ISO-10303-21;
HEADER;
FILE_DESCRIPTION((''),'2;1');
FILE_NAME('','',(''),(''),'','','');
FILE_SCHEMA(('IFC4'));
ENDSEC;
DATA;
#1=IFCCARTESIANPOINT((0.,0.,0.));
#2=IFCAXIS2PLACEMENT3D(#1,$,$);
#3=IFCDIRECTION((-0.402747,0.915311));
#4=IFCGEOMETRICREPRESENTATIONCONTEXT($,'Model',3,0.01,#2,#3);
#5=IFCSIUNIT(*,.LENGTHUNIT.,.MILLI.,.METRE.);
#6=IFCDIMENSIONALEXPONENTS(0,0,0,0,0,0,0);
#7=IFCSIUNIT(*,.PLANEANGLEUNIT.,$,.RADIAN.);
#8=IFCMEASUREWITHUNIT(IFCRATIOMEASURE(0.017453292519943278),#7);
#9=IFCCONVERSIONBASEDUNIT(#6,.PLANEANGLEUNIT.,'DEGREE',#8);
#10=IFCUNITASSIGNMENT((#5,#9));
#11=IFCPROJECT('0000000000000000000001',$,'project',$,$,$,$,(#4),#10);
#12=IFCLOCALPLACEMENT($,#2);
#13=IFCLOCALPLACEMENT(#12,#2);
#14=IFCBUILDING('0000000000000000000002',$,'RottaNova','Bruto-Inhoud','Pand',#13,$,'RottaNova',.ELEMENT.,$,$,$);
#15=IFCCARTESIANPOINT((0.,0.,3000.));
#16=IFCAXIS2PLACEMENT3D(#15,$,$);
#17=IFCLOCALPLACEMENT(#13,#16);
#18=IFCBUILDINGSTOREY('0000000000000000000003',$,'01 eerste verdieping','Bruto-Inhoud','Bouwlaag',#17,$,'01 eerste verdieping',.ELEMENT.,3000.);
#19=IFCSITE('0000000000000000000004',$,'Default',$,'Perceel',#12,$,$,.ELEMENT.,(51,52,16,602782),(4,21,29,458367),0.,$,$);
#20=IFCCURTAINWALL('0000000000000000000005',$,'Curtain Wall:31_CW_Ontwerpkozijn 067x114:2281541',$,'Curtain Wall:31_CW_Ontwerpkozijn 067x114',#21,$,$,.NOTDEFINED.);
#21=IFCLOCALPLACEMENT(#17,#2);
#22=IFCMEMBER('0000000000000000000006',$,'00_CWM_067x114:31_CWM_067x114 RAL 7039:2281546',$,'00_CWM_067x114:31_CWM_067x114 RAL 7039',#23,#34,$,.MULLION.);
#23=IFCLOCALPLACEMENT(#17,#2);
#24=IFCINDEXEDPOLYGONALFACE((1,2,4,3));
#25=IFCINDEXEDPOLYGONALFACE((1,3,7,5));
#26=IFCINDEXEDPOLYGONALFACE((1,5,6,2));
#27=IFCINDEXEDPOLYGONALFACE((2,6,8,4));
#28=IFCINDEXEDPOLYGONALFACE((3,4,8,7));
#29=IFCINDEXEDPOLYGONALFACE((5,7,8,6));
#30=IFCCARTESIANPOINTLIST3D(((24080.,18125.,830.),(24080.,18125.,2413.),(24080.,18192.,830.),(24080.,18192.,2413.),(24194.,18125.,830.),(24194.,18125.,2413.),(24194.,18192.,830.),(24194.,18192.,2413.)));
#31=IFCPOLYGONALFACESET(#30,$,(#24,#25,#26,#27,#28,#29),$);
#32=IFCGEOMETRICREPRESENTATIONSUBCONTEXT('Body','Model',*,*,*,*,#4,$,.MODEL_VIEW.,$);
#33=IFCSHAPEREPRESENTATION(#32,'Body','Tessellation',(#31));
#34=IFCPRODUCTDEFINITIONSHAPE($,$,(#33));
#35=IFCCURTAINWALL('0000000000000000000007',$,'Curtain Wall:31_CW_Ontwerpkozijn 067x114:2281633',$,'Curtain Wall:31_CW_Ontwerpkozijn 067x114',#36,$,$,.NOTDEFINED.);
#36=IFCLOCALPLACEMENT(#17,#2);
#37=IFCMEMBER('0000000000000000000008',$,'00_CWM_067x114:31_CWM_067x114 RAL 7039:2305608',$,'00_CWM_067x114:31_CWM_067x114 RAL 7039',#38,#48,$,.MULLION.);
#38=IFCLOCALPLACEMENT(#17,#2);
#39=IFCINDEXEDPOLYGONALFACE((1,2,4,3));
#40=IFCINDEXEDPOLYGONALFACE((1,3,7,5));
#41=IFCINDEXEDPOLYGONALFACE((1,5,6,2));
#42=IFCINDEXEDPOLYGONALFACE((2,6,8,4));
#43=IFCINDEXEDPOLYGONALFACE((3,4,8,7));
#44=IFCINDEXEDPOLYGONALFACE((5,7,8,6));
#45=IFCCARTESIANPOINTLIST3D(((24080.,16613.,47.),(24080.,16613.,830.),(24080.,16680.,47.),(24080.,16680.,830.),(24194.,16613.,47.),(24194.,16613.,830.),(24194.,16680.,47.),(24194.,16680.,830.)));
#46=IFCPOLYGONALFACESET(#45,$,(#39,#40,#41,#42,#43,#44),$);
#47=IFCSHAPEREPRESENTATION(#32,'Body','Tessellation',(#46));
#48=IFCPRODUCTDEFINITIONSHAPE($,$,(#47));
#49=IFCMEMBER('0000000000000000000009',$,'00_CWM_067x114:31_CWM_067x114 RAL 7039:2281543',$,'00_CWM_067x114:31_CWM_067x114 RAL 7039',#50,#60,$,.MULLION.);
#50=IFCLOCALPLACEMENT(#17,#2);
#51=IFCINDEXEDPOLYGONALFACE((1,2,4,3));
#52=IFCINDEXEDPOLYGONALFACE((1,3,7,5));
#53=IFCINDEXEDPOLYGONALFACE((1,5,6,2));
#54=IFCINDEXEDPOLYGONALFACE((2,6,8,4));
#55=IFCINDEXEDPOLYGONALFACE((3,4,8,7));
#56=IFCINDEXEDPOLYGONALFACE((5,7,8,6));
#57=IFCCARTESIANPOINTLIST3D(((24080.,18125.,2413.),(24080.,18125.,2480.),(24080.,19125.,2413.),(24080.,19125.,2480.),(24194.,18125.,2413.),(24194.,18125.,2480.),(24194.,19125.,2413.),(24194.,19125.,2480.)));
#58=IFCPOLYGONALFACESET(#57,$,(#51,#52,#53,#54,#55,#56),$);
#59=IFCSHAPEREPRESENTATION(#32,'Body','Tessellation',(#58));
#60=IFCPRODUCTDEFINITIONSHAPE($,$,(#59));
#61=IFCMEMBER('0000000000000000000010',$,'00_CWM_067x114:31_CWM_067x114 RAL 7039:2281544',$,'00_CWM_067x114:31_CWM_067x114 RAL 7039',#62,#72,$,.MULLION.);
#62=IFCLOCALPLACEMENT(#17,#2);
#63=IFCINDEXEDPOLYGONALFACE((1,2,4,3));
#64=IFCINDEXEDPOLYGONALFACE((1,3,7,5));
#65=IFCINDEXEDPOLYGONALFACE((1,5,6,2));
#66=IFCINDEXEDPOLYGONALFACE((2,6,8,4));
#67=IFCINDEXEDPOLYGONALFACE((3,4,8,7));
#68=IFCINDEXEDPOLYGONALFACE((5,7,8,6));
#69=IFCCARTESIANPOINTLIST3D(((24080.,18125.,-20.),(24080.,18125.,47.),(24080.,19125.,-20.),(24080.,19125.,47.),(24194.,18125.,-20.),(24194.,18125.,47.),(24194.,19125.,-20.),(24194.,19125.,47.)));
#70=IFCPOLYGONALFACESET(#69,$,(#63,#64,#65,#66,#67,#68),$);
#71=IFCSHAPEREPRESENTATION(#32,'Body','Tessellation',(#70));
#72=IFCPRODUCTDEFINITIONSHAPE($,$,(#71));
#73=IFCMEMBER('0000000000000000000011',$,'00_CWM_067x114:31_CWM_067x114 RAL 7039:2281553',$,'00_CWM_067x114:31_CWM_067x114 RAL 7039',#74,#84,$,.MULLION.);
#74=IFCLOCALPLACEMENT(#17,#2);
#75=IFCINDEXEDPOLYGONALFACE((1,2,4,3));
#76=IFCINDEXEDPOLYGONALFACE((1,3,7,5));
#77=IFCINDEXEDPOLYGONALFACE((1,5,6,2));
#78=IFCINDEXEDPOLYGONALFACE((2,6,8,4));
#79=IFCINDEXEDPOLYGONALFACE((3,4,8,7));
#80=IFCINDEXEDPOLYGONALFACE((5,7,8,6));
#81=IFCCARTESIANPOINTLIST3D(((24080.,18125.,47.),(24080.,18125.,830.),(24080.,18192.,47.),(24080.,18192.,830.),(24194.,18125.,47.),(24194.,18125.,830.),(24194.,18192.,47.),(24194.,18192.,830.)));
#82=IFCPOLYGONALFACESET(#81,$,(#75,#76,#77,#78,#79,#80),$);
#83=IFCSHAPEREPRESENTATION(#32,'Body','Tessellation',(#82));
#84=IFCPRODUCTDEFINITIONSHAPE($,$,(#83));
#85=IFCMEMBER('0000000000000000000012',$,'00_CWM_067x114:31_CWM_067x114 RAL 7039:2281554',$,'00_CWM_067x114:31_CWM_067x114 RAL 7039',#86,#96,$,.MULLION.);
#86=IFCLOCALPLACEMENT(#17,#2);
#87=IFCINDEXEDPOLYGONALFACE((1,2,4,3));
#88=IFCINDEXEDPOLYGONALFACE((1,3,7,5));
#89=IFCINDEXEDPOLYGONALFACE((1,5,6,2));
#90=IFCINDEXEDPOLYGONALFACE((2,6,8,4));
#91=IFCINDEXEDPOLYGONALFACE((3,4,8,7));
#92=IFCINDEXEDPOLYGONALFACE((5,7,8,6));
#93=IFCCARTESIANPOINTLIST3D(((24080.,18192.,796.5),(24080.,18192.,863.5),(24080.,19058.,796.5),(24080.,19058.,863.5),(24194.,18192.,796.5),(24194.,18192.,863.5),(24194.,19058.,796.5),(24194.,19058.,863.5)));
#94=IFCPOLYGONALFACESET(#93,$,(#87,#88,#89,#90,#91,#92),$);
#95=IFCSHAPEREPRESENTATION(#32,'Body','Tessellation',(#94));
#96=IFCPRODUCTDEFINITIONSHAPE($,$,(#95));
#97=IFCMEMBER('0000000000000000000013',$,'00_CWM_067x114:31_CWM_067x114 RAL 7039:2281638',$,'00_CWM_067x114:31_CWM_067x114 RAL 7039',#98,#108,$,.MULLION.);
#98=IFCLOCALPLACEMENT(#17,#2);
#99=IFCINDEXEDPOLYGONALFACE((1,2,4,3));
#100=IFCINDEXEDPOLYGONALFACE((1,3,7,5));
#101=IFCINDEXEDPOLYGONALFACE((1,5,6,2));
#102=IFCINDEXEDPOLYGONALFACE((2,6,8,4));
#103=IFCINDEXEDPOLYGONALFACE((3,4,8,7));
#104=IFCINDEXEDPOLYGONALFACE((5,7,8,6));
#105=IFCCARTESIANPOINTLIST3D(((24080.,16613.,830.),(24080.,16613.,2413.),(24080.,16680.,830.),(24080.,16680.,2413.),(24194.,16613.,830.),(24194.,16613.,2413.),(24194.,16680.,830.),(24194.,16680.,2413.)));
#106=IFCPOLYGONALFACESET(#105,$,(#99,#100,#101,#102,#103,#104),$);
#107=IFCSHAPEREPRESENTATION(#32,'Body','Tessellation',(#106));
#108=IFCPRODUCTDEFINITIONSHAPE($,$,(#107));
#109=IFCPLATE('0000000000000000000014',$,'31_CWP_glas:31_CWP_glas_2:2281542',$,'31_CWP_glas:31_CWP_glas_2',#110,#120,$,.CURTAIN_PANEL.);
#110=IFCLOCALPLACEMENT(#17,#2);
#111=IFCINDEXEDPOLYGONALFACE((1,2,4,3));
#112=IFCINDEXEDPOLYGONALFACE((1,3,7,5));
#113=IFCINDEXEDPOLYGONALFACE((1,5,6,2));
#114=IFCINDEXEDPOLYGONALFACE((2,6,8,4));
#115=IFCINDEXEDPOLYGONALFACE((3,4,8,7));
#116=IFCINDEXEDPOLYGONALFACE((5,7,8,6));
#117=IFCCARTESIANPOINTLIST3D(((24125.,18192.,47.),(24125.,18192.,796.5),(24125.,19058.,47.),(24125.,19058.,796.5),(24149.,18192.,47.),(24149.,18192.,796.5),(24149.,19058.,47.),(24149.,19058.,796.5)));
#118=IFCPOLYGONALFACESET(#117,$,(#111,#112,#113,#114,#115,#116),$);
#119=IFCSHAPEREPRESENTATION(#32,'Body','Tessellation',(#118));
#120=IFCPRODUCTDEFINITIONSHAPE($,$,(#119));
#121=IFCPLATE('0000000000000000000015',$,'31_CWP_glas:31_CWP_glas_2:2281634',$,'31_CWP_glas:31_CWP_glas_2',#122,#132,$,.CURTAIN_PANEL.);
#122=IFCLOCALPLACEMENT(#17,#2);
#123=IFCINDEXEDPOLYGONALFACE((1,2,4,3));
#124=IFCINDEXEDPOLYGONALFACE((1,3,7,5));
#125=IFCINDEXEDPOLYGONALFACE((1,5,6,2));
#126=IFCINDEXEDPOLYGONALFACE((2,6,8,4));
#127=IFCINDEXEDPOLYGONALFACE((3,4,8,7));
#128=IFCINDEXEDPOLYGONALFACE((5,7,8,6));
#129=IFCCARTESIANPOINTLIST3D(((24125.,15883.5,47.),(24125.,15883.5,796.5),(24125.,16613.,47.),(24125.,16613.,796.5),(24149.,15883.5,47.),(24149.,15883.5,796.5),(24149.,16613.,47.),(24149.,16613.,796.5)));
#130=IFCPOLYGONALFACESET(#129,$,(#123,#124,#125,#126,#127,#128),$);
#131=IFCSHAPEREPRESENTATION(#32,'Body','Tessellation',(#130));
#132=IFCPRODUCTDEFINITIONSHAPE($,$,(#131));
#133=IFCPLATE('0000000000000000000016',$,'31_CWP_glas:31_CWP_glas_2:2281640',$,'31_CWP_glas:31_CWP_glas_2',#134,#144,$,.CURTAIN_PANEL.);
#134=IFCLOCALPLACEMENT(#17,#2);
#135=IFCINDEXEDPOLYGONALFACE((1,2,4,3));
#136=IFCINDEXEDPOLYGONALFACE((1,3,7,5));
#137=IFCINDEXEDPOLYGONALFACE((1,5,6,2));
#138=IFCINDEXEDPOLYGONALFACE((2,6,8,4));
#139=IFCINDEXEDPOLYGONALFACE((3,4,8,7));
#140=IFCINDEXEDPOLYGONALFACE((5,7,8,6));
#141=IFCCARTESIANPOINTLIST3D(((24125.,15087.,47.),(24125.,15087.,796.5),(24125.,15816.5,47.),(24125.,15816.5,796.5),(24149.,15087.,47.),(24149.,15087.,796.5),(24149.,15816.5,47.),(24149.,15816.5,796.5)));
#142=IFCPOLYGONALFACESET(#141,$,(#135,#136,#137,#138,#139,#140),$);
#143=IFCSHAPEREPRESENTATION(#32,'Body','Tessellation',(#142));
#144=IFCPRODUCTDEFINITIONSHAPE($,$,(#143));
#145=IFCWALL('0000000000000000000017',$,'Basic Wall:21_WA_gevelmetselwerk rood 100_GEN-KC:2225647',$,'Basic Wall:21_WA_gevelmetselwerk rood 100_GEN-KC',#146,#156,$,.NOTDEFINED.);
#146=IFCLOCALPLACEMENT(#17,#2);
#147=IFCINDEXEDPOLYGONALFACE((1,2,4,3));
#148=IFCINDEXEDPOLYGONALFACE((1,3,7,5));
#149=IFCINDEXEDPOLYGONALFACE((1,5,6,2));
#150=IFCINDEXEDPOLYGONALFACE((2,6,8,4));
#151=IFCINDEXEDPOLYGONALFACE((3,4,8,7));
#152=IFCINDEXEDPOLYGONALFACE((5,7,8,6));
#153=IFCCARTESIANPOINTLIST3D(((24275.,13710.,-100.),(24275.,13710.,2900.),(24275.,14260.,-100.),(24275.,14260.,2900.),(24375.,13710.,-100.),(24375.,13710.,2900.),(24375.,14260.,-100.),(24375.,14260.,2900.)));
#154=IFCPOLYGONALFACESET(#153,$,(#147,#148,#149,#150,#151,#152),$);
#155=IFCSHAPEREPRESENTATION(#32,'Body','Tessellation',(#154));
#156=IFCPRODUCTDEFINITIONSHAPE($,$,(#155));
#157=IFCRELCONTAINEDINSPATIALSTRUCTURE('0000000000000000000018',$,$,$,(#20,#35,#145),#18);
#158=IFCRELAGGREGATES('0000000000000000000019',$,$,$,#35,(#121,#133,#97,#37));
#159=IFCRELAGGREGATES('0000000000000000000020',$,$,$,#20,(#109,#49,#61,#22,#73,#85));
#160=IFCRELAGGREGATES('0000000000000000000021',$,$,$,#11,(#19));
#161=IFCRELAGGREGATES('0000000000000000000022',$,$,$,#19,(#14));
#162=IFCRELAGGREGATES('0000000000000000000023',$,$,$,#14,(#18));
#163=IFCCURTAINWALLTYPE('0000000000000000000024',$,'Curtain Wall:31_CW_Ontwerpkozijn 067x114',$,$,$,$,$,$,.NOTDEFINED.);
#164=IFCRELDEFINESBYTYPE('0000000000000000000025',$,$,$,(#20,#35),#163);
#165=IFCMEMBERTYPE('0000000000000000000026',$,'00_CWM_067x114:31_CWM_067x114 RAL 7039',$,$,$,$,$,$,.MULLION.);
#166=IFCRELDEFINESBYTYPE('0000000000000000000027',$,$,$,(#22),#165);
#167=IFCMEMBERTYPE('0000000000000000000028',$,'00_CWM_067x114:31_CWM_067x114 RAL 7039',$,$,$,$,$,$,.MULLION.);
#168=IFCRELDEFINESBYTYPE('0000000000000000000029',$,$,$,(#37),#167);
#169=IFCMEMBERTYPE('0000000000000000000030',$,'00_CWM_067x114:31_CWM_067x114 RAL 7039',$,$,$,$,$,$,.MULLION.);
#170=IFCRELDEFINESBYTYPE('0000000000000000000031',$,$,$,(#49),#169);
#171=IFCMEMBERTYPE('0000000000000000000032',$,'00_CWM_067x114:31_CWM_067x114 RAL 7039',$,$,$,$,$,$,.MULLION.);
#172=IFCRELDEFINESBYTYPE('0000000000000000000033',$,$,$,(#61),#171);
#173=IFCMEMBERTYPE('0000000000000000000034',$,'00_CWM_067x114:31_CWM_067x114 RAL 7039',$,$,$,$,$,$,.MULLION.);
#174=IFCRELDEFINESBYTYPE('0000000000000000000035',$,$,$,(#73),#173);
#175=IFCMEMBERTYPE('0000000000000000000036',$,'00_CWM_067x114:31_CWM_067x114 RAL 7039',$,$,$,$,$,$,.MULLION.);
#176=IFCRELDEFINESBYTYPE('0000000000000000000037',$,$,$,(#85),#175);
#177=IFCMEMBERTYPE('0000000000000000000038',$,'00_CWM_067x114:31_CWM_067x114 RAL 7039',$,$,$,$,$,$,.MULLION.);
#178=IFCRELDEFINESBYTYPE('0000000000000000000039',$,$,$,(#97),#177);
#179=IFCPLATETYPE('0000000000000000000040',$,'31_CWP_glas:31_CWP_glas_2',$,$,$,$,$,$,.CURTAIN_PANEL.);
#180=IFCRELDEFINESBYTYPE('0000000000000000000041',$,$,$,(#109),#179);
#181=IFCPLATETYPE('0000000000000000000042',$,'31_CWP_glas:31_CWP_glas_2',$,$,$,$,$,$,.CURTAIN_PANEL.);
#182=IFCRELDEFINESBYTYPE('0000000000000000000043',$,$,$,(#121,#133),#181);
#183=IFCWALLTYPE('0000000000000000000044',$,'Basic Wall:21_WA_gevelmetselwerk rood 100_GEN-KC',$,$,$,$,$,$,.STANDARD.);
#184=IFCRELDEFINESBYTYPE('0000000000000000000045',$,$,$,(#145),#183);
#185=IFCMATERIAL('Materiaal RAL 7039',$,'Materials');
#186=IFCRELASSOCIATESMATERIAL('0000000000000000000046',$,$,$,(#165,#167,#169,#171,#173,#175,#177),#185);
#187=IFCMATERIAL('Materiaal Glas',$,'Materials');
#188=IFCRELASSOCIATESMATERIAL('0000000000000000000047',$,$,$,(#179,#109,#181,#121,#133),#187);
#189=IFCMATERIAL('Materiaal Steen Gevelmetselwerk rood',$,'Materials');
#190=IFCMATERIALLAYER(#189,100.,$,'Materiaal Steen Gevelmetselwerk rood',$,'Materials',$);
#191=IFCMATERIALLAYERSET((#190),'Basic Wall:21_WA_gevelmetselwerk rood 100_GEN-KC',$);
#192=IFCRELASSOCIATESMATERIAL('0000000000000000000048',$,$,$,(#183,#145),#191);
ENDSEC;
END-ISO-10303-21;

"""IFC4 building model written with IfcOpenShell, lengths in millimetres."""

from ifc_helpers import new_model, entity, si_unit, converted_unit, direction, frame, frame_2d, origin, origin_2d_with_axis, place, context, subcontext, project, spatial, rectangle, extrude, source, transform, mapped, material, layer, layer_set, material_profile, profile_set, type_object, type_shapes, element, aggregate, save


model = new_model("IFC4")

# Units and contexts
model_context = context("Model", 3, precision=0.01, world=origin(), true_north=direction((-0.402747, 0.915311)))
body_context = subcontext(model_context, "Body", "Model", "MODEL_VIEW")
ifc_project = project(units=[si_unit("LENGTHUNIT", "METRE", prefix="MILLI"), converted_unit("PLANEANGLEUNIT", "DEGREE", entity("IfcRatioMeasure", 0.017453292519943278), si_unit("PLANEANGLEUNIT", "RADIAN"), dimensions=[0, 0, 0, 0, 0, 0, 0])], contexts=[model_context])

# Site, building, storey
site_placement = place(None, origin())
site = spatial("IfcSite", under=ifc_project, at=site_placement, Name="Default", ObjectType="Perceel", CompositionType="ELEMENT", RefLatitude=(51, 52, 16, 602782), RefLongitude=(4, 21, 29, 458367), RefElevation=0.0)
building_placement = place(site_placement, origin())
building = spatial("IfcBuilding", under=site, at=building_placement, Name="RottaNova", Description="Bruto-Inhoud", ObjectType="Pand", LongName="RottaNova", CompositionType="ELEMENT")
storey_placement = place(building_placement, frame((0.0, 0.0, 3000.0)))
storey = spatial("IfcBuildingStorey", under=building, at=storey_placement, Name="01 eerste verdieping", Description="Bruto-Inhoud", ObjectType="Bouwlaag", LongName="01 eerste verdieping", CompositionType="ELEMENT", Elevation=3000.0)

# Curtain walls, members
curtain_wall_type = type_object("IfcCurtainWallType", Name="Curtain Wall:31_CW_Ontwerpkozijn 067x114", PredefinedType="NOTDEFINED")
curtain_wall_1_placement = place(storey_placement, frame((0.0, 0.0, -3000.0)))
curtain_wall_1 = element("IfcCurtainWall", 1, at=curtain_wall_1_placement, inside=storey, type_object=curtain_wall_type, Name="Curtain Wall:31_CW_Ontwerpkozijn 067x114:2281541", ObjectType="Curtain Wall:31_CW_Ontwerpkozijn 067x114", PredefinedType="NOTDEFINED")
ifc_material_1 = material(Name="Materiaal RAL 7039", Category="Materials")
ifc_material_profile = material_profile(ifc_material_1, rectangle(XDim=114.0, YDim=67.0, at=origin_2d_with_axis()), Name="31_CWM_067x114 RAL 7039")
ifc_profile_set = profile_set([ifc_material_profile], Name="31_CWM_067x114 RAL 7039")
member_type_1 = type_object("IfcMemberType", Name="00_CWM_067x114:31_CWM_067x114 RAL 7039", PredefinedType="MULLION", material=ifc_profile_set)
shared_shape_1 = source(origin(), body_context, "Body", "SweptSolid", [
    extrude(rectangle(XDim=114.0, YDim=67.0, at=origin_2d_with_axis()), frame((-33.5, 57.0, -1583.0), z_axis=(0.0, 0.0, 1.0), x_axis=(0.0, -1.0, 0.0)), (0.0, 0.0, 1.0), 1583.0),
])
type_shapes(member_type_1, [shared_shape_1])
member_1_placement = place(curtain_wall_1_placement, frame((24080.0, 18125.0, 5413.0), z_axis=(0.0, 0.0, 1.0), x_axis=(0.0, -1.0, 0.0)))
member_1 = element("IfcMember", 2, at=member_1_placement, type_object=member_type_1, Name="00_CWM_067x114:31_CWM_067x114 RAL 7039:2281546", ObjectType="00_CWM_067x114:31_CWM_067x114 RAL 7039", PredefinedType="MULLION", context=body_context, shape_type="MappedRepresentation", body=[
    mapped(shared_shape_1, transform((0.0, 0.0, 0.0), scale=1.0)),
])
curtain_wall_2_placement = place(storey_placement, frame((0.0, 0.0, -3000.0)))
curtain_wall_2 = element("IfcCurtainWall", 3, at=curtain_wall_2_placement, inside=storey, type_object=curtain_wall_type, Name="Curtain Wall:31_CW_Ontwerpkozijn 067x114:2281633", ObjectType="Curtain Wall:31_CW_Ontwerpkozijn 067x114", PredefinedType="NOTDEFINED")
member_type_2 = type_object("IfcMemberType", Name="00_CWM_067x114:31_CWM_067x114 RAL 7039", PredefinedType="MULLION", material=ifc_profile_set)
shared_shape_2 = source(origin(), body_context, "Body", "SweptSolid", [
    extrude(rectangle(XDim=114.0, YDim=67.0, at=frame_2d((0.0, 0.0), x_axis=(1.0, 0.0))), frame((-33.5, -57.0, -783.0), z_axis=(0.0, 0.0, 1.0), x_axis=(0.0, -1.0, 0.0)), (0.0, 0.0, 1.0), 783.0),
])
type_shapes(member_type_2, [shared_shape_2])
member_2_placement = place(curtain_wall_2_placement, frame((24080.0, 16680.0, 3830.0), z_axis=(0.0, 0.0, 1.0), x_axis=(0.0, 1.0, 0.0)))
member_2 = element("IfcMember", 4, at=member_2_placement, type_object=member_type_2, Name="00_CWM_067x114:31_CWM_067x114 RAL 7039:2305608", ObjectType="00_CWM_067x114:31_CWM_067x114 RAL 7039", PredefinedType="MULLION", context=body_context, shape_type="MappedRepresentation", body=[
    mapped(shared_shape_2, transform((0.0, 0.0, 0.0), scale=1.0)),
])

# Members
member_type_3 = type_object("IfcMemberType", Name="00_CWM_067x114:31_CWM_067x114 RAL 7039", PredefinedType="MULLION", material=ifc_profile_set)
shared_shape_3 = source(origin(), body_context, "Body", "SweptSolid", [
    extrude(rectangle(XDim=114.0, YDim=67.0, at=origin_2d_with_axis()), frame((-33.5, 57.0, -1000.0), z_axis=(0.0, 0.0, 1.0), x_axis=(0.0, -1.0, 0.0)), (0.0, 0.0, 1.0), 1000.0),
])
type_shapes(member_type_3, [shared_shape_3])
member_3_placement = place(curtain_wall_1_placement, frame((24080.0, 19125.0, 5480.0), z_axis=(0.0, 1.0, 0.0), x_axis=(0.0, 0.0, 1.0)))
member_3 = element("IfcMember", 5, at=member_3_placement, type_object=member_type_3, Name="00_CWM_067x114:31_CWM_067x114 RAL 7039:2281543", ObjectType="00_CWM_067x114:31_CWM_067x114 RAL 7039", PredefinedType="MULLION", context=body_context, shape_type="MappedRepresentation", body=[
    mapped(shared_shape_3, transform((0.0, 0.0, 0.0), scale=1.0)),
])
member_type_4 = type_object("IfcMemberType", Name="00_CWM_067x114:31_CWM_067x114 RAL 7039", PredefinedType="MULLION", material=ifc_profile_set)
shared_shape_4 = source(origin(), body_context, "Body", "SweptSolid", [
    extrude(rectangle(XDim=114.0, YDim=67.0, at=origin_2d_with_axis()), frame((-33.5, 57.0, -1000.0), z_axis=(0.0, 0.0, 1.0), x_axis=(0.0, -1.0, 0.0)), (0.0, 0.0, 1.0), 1000.0),
])
type_shapes(member_type_4, [shared_shape_4])
member_4_placement = place(curtain_wall_1_placement, frame((24080.0, 18125.0, 2980.0), z_axis=(0.0, -1.0, 0.0), x_axis=(0.0, 0.0, -1.0)))
member_4 = element("IfcMember", 6, at=member_4_placement, type_object=member_type_4, Name="00_CWM_067x114:31_CWM_067x114 RAL 7039:2281544", ObjectType="00_CWM_067x114:31_CWM_067x114 RAL 7039", PredefinedType="MULLION", context=body_context, shape_type="MappedRepresentation", body=[
    mapped(shared_shape_4, transform((0.0, 0.0, 0.0), scale=1.0)),
])
member_type_5 = type_object("IfcMemberType", Name="00_CWM_067x114:31_CWM_067x114 RAL 7039", PredefinedType="MULLION", material=ifc_profile_set)
shared_shape_5 = source(origin(), body_context, "Body", "SweptSolid", [
    extrude(rectangle(XDim=114.0, YDim=67.0, at=origin_2d_with_axis()), frame((-33.5, 57.0, -783.0), z_axis=(0.0, 0.0, 1.0), x_axis=(0.0, -1.0, 0.0)), (0.0, 0.0, 1.0), 783.0),
])
type_shapes(member_type_5, [shared_shape_5])
member_5_placement = place(curtain_wall_1_placement, frame((24080.0, 18125.0, 3830.0), z_axis=(0.0, 0.0, 1.0), x_axis=(0.0, -1.0, 0.0)))
member_5 = element("IfcMember", 7, at=member_5_placement, type_object=member_type_5, Name="00_CWM_067x114:31_CWM_067x114 RAL 7039:2281553", ObjectType="00_CWM_067x114:31_CWM_067x114 RAL 7039", PredefinedType="MULLION", context=body_context, shape_type="MappedRepresentation", body=[
    mapped(shared_shape_5, transform((0.0, 0.0, 0.0), scale=1.0)),
])
member_type_6 = type_object("IfcMemberType", Name="00_CWM_067x114:31_CWM_067x114 RAL 7039", PredefinedType="MULLION", material=ifc_profile_set)
shared_shape_6 = source(origin(), body_context, "Body", "SweptSolid", [
    extrude(rectangle(XDim=114.0, YDim=67.0, at=origin_2d_with_axis()), frame((0.0, 57.0, -866.0), z_axis=(0.0, 0.0, 1.0), x_axis=(0.0, -1.0, 0.0)), (0.0, 0.0, 1.0), 866.0),
])
type_shapes(member_type_6, [shared_shape_6])
member_6_placement = place(curtain_wall_1_placement, frame((24080.0, 19058.0, 3830.0), z_axis=(0.0, 1.0, 0.0), x_axis=(0.0, 0.0, 1.0)))
member_6 = element("IfcMember", 8, at=member_6_placement, type_object=member_type_6, Name="00_CWM_067x114:31_CWM_067x114 RAL 7039:2281554", ObjectType="00_CWM_067x114:31_CWM_067x114 RAL 7039", PredefinedType="MULLION", context=body_context, shape_type="MappedRepresentation", body=[
    mapped(shared_shape_6, transform((0.0, 0.0, 0.0), scale=1.0)),
])
member_type_7 = type_object("IfcMemberType", Name="00_CWM_067x114:31_CWM_067x114 RAL 7039", PredefinedType="MULLION", material=ifc_profile_set)
shared_shape_7 = source(origin(), body_context, "Body", "SweptSolid", [
    extrude(rectangle(XDim=114.0, YDim=67.0, at=origin_2d_with_axis()), frame((-33.5, -57.0, -1583.0), z_axis=(0.0, 0.0, 1.0), x_axis=(0.0, -1.0, 0.0)), (0.0, 0.0, 1.0), 1583.0),
])
type_shapes(member_type_7, [shared_shape_7])
member_7_placement = place(curtain_wall_2_placement, frame((24080.0, 16680.0, 5413.0), z_axis=(0.0, 0.0, 1.0), x_axis=(0.0, 1.0, 0.0)))
member_7 = element("IfcMember", 9, at=member_7_placement, type_object=member_type_7, Name="00_CWM_067x114:31_CWM_067x114 RAL 7039:2281638", ObjectType="00_CWM_067x114:31_CWM_067x114 RAL 7039", PredefinedType="MULLION", context=body_context, shape_type="MappedRepresentation", body=[
    mapped(shared_shape_7, transform((0.0, 0.0, 0.0), scale=1.0)),
])

# Plates
ifc_material_2 = material(Name="Materiaal Glas", Category="Materials")
plate_type_1 = type_object("IfcPlateType", Name="31_CWP_glas:31_CWP_glas_2", PredefinedType="CURTAIN_PANEL", material=ifc_material_2)
shared_shape_8 = source(origin(), body_context, "Body", "SweptSolid", [
    extrude(rectangle(XDim=24.0, YDim=866.0, at=frame_2d((0.0, 0.0), x_axis=(1.0, 0.0))), frame((433.0, 12.0, 0.0), z_axis=(0.0, 0.0, 1.0), x_axis=(0.0, 1.0, 0.0)), (0.0, 0.0, 1.0), 749.5),
])
type_shapes(plate_type_1, [shared_shape_8])
plate_1_placement = place(curtain_wall_1_placement, frame((24149.0, 18192.0, 3047.0), z_axis=(0.0, 0.0, 1.0), x_axis=(0.0, 1.0, 0.0)))
plate_1 = element("IfcPlate", 10, at=plate_1_placement, type_object=plate_type_1, material=ifc_material_2, Name="31_CWP_glas:31_CWP_glas_2:2281542", ObjectType="31_CWP_glas:31_CWP_glas_2", PredefinedType="CURTAIN_PANEL", context=body_context, shape_type="MappedRepresentation", body=[
    mapped(shared_shape_8, transform((0.0, 0.0, 0.0), scale=1.0)),
])
plate_type_2 = type_object("IfcPlateType", Name="31_CWP_glas:31_CWP_glas_2", PredefinedType="CURTAIN_PANEL", material=ifc_material_2)
shared_shape_9 = source(origin(), body_context, "Body", "SweptSolid", [
    extrude(rectangle(XDim=24.0, YDim=729.5, at=frame_2d((0.0, 0.0), x_axis=(1.0, 0.0))), frame((364.7, 12.0, 0.0), z_axis=(0.0, 0.0, 1.0), x_axis=(0.0, 1.0, 0.0)), (0.0, 0.0, 1.0), 749.5),
])
type_shapes(plate_type_2, [shared_shape_9])
plate_2_placement = place(curtain_wall_2_placement, frame((24125.0, 16613.0, 3047.0), z_axis=(0.0, 0.0, 1.0), x_axis=(0.0, -1.0, 0.0)))
plate_2 = element("IfcPlate", 11, at=plate_2_placement, type_object=plate_type_2, material=ifc_material_2, Name="31_CWP_glas:31_CWP_glas_2:2281634", ObjectType="31_CWP_glas:31_CWP_glas_2", PredefinedType="CURTAIN_PANEL", context=body_context, shape_type="MappedRepresentation", body=[
    mapped(shared_shape_9, transform((0.0, 0.0, 0.0), scale=1.0)),
])
plate_3_placement = place(curtain_wall_2_placement, frame((24125.0, 15816.5, 3047.0), z_axis=(0.0, 0.0, 1.0), x_axis=(0.0, -1.0, 0.0)))
plate_3 = element("IfcPlate", 12, at=plate_3_placement, type_object=plate_type_2, material=ifc_material_2, Name="31_CWP_glas:31_CWP_glas_2:2281640", ObjectType="31_CWP_glas:31_CWP_glas_2", PredefinedType="CURTAIN_PANEL", context=body_context, shape_type="MappedRepresentation", body=[
    mapped(shared_shape_9, transform((0.0, 0.0, 0.0), scale=1.0)),
])
aggregate(curtain_wall_2, [plate_2, plate_3, member_7, member_2])

# Shared definitions
ifc_material_3 = material(Name="Materiaal Steen Gevelmetselwerk rood", Category="Materials")
ifc_layer_1 = layer(ifc_material_3, 100.0, Name="Materiaal Steen Gevelmetselwerk rood", Category="Materials")
ifc_layer_set_1 = layer_set([ifc_layer_1], Name="Basic Wall:21_WA_gevelmetselwerk rood 100_GEN-KC")
wall_type_1 = type_object("IfcWallType", Name="Basic Wall:21_WA_gevelmetselwerk rood 100_GEN-KC", PredefinedType="STANDARD", material=ifc_layer_set_1)

# Wall
wall_1_placement = place(storey_placement, frame((24325.0, 13710.0, -100.0), z_axis=(0.0, 0.0, 1.0), x_axis=(0.0, 1.0, 0.0)))
element("IfcWall", 13, at=wall_1_placement, inside=storey, type_object=wall_type_1, material=ifc_layer_set_1, Name="Basic Wall:21_WA_gevelmetselwerk rood 100_GEN-KC:2225647", ObjectType="Basic Wall:21_WA_gevelmetselwerk rood 100_GEN-KC", PredefinedType="NOTDEFINED", context=body_context, shape_type="SweptSolid", body=[
    extrude(rectangle(XDim=550.0, YDim=100.0, at=frame_2d((275.0, 0.0), x_axis=(-1.0, 0.0))), origin(), (0.0, 0.0, 1.0), 3000.0),
])

aggregate(curtain_wall_1, [plate_1, member_3, member_4, member_1, member_5, member_6])

save(model, "model.ifc")
